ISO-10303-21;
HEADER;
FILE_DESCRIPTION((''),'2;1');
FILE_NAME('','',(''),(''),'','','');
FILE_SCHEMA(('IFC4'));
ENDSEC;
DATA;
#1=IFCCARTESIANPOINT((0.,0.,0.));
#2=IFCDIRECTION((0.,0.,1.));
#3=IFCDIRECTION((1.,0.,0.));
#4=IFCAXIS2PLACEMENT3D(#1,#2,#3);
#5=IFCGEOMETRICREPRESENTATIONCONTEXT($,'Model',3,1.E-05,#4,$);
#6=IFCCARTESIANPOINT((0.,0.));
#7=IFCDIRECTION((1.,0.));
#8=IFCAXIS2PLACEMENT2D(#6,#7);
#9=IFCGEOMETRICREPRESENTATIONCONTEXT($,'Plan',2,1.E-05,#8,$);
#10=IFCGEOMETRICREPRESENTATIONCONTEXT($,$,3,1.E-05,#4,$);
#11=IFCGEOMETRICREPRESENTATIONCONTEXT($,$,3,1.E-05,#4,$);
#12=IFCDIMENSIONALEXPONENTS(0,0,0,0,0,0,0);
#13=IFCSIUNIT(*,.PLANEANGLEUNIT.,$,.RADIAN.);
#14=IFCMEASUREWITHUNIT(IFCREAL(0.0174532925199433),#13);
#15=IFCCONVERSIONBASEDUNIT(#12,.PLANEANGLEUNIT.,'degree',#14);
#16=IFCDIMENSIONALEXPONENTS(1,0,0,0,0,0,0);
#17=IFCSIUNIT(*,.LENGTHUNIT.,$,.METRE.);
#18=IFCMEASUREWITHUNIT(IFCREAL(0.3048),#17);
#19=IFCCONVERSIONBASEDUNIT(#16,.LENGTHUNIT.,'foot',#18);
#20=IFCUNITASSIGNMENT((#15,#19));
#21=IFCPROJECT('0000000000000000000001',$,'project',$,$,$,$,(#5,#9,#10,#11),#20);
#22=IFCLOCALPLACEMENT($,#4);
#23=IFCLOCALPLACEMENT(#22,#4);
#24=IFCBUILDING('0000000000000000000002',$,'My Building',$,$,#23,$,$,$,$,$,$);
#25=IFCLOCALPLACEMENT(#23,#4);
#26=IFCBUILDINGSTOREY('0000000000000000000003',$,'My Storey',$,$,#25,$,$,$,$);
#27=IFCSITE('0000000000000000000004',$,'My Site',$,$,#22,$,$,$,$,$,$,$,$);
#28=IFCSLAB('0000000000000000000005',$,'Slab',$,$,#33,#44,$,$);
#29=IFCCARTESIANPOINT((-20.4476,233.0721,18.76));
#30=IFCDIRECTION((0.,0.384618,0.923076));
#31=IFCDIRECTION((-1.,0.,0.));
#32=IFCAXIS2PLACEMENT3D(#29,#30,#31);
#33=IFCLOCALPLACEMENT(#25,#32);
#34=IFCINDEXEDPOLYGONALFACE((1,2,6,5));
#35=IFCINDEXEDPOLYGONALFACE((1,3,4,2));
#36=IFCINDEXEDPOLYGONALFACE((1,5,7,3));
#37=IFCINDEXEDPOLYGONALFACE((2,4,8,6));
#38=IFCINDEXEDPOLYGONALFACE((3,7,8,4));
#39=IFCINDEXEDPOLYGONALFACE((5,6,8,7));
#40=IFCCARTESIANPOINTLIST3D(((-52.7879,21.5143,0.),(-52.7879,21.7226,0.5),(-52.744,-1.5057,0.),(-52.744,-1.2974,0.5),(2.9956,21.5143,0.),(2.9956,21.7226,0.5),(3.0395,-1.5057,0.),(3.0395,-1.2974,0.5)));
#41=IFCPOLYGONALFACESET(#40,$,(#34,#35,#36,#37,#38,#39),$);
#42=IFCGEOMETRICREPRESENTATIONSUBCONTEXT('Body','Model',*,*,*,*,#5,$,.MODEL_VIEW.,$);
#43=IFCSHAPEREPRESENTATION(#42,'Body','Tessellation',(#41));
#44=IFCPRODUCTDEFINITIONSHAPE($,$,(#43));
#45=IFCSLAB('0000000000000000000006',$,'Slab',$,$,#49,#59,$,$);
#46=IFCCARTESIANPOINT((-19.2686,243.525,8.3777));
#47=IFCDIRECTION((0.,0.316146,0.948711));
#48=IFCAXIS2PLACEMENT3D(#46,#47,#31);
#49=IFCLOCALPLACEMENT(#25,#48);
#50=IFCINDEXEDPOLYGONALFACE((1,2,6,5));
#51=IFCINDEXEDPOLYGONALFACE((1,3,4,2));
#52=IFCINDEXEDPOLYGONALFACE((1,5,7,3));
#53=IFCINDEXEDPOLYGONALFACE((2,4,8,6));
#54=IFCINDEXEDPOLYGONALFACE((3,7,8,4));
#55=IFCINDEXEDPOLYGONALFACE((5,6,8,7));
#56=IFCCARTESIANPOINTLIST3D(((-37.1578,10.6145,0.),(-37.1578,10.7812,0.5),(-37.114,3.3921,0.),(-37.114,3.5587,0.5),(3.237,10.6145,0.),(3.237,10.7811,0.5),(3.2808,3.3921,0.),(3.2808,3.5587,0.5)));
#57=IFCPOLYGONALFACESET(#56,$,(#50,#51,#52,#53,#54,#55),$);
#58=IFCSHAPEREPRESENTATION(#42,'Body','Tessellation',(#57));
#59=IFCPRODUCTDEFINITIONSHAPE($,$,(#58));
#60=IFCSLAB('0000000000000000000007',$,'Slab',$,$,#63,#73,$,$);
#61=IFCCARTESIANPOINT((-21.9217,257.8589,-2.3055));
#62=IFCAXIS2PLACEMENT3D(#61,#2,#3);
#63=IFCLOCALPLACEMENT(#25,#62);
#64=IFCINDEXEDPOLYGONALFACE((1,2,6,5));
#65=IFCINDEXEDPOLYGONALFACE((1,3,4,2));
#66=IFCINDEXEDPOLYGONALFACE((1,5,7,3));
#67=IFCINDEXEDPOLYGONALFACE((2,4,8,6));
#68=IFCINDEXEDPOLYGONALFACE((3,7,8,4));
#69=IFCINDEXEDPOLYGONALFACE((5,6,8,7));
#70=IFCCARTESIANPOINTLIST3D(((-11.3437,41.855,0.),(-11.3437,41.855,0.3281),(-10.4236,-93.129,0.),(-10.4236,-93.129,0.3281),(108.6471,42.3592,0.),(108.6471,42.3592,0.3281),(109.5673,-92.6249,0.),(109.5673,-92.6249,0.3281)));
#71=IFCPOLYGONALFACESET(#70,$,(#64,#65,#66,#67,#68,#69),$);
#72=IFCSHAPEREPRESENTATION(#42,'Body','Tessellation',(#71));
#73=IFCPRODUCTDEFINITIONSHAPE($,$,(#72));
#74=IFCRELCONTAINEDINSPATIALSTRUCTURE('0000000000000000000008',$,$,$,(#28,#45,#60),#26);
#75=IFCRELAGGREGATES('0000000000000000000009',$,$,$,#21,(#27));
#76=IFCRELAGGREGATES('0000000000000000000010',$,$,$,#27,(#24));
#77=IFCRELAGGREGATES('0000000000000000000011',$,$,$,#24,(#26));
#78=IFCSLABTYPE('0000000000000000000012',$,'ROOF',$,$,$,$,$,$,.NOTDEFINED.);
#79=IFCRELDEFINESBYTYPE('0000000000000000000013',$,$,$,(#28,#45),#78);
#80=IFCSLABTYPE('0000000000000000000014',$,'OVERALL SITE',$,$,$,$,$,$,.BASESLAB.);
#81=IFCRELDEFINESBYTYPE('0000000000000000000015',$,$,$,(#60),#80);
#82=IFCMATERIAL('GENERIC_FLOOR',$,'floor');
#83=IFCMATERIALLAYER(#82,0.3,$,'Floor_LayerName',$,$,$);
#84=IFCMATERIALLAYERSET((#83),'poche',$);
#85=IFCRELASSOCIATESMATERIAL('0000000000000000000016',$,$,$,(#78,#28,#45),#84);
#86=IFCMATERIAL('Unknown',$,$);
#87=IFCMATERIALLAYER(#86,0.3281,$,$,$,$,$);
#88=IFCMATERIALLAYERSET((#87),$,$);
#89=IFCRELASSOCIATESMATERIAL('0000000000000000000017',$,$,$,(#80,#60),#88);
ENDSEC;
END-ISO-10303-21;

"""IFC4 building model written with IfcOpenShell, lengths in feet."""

from ifc_helpers import new_model, entity, si_unit, converted_unit, frame, origin_with_axes, origin_2d_with_axis, place, context, subcontext, project, spatial, line, indexed_curve, outline, extrude, material, layer, layer_set, layer_usage, type_object, element, save


model = new_model("IFC4")

# Units and contexts
model_context = context("Model", 3, precision=1e-05, world=origin_with_axes())
plan_context = context("Plan", 2, precision=1e-05, world=origin_2d_with_axis())
context_of_model_1 = context(None, 3, precision=1e-05, world=origin_with_axes())
context_of_model_2 = context(None, 3, precision=1e-05, world=origin_with_axes())
body_context = subcontext(model_context, "Body", "Model", "MODEL_VIEW")
ifc_project = project(units=[converted_unit("PLANEANGLEUNIT", "degree", entity("IfcReal", 0.0174532925199433), si_unit("PLANEANGLEUNIT", "RADIAN"), dimensions=[0, 0, 0, 0, 0, 0, 0]), converted_unit("LENGTHUNIT", "foot", entity("IfcReal", 0.3048), si_unit("LENGTHUNIT", "METRE"), dimensions=[1, 0, 0, 0, 0, 0, 0])], contexts=[model_context, plan_context, context_of_model_1, context_of_model_2])

# Site, building, storey
site_placement = place(None, origin_with_axes())
site = spatial("IfcSite", under=ifc_project, at=site_placement, Name="My Site")
building_placement = place(site_placement, origin_with_axes())
building = spatial("IfcBuilding", under=site, at=building_placement, Name="My Building")
storey_placement = place(building_placement, origin_with_axes())
storey = spatial("IfcBuildingStorey", under=building, at=storey_placement, Name="My Storey")

# Slabs
ifc_material_1 = material(Name="GENERIC_FLOOR", Category="floor")
ifc_layer_1 = layer(ifc_material_1, 0.3, Name="Floor_LayerName")
ifc_layer_set_1 = layer_set([ifc_layer_1], Name="poche")
ifc_layer_usage_1 = layer_usage(ifc_layer_set_1, "AXIS3", "POSITIVE", 0.0)
slab_type_1 = type_object("IfcSlabType", Name="ROOF", PredefinedType="NOTDEFINED", material=ifc_layer_set_1)
slab_1_placement = place(storey_placement, frame((-20.4476, 233.0721, 18.76), z_axis=(0.0, 0.384618, 0.923076), x_axis=(-1.0, 0.0, 0.0)))
element("IfcSlab", 1, at=slab_1_placement, inside=storey, type_object=slab_type_1, material=ifc_layer_usage_1, Name="Slab", context=body_context, shape_type="SweptSolid", body=[
    extrude(outline(indexed_curve([(2.9956, 21.5143), (3.0395, -1.5057), (-52.744, -1.5057), (-52.7879, 21.5143)], segments=[line(3, 2), line(2, 1), line(1, 4), line(4, 3)], self_intersect=False)), None, (0.0, 0.384618, 0.923076), 0.5417),
])
ifc_layer_usage_2 = layer_usage(ifc_layer_set_1, "AXIS3", "POSITIVE", 0.0)
slab_2_placement = place(storey_placement, frame((-19.2686, 243.525, 8.3777), z_axis=(0.0, 0.316146, 0.948711), x_axis=(-1.0, 0.0, 0.0)))
element("IfcSlab", 2, at=slab_2_placement, inside=storey, type_object=slab_type_1, material=ifc_layer_usage_2, Name="Slab", context=body_context, shape_type="SweptSolid", body=[
    extrude(outline(indexed_curve([(-37.1578, 10.6145), (3.237, 10.6145), (3.2808, 3.3921), (-37.114, 3.3921)], segments=[line(4, 1), line(1, 2), line(2, 3), line(3, 4)], self_intersect=False)), None, (0.0, 0.316146, 0.948711), 0.527),
])
ifc_material_2 = material(Name="Unknown")
ifc_layer_2 = layer(ifc_material_2, 0.3281)
ifc_layer_set_2 = layer_set([ifc_layer_2])
ifc_layer_usage_3 = layer_usage(ifc_layer_set_2, "AXIS3", "POSITIVE", 0.0)
slab_type_2 = type_object("IfcSlabType", Name="OVERALL SITE", PredefinedType="BASESLAB", material=ifc_layer_set_2)
slab_3_placement = place(storey_placement, frame((-21.9217, 257.8589, -2.3055), z_axis=(0.0, 0.0, 1.0), x_axis=(1.0, 0.0, 0.0)))
element("IfcSlab", 3, at=slab_3_placement, inside=storey, type_object=slab_type_2, material=ifc_layer_usage_3, Name="Slab", context=body_context, shape_type="SweptSolid", body=[
    extrude(outline(indexed_curve([(-11.3437, 41.855), (108.6471, 42.3592), (109.5673, -92.6249), (-10.4236, -93.129)], segments=[line(3, 2), line(2, 1), line(1, 4), line(4, 3)], self_intersect=False)), None, (0.0, 0.0, 1.0), 0.3281),
])

save(model, "model.ifc")
